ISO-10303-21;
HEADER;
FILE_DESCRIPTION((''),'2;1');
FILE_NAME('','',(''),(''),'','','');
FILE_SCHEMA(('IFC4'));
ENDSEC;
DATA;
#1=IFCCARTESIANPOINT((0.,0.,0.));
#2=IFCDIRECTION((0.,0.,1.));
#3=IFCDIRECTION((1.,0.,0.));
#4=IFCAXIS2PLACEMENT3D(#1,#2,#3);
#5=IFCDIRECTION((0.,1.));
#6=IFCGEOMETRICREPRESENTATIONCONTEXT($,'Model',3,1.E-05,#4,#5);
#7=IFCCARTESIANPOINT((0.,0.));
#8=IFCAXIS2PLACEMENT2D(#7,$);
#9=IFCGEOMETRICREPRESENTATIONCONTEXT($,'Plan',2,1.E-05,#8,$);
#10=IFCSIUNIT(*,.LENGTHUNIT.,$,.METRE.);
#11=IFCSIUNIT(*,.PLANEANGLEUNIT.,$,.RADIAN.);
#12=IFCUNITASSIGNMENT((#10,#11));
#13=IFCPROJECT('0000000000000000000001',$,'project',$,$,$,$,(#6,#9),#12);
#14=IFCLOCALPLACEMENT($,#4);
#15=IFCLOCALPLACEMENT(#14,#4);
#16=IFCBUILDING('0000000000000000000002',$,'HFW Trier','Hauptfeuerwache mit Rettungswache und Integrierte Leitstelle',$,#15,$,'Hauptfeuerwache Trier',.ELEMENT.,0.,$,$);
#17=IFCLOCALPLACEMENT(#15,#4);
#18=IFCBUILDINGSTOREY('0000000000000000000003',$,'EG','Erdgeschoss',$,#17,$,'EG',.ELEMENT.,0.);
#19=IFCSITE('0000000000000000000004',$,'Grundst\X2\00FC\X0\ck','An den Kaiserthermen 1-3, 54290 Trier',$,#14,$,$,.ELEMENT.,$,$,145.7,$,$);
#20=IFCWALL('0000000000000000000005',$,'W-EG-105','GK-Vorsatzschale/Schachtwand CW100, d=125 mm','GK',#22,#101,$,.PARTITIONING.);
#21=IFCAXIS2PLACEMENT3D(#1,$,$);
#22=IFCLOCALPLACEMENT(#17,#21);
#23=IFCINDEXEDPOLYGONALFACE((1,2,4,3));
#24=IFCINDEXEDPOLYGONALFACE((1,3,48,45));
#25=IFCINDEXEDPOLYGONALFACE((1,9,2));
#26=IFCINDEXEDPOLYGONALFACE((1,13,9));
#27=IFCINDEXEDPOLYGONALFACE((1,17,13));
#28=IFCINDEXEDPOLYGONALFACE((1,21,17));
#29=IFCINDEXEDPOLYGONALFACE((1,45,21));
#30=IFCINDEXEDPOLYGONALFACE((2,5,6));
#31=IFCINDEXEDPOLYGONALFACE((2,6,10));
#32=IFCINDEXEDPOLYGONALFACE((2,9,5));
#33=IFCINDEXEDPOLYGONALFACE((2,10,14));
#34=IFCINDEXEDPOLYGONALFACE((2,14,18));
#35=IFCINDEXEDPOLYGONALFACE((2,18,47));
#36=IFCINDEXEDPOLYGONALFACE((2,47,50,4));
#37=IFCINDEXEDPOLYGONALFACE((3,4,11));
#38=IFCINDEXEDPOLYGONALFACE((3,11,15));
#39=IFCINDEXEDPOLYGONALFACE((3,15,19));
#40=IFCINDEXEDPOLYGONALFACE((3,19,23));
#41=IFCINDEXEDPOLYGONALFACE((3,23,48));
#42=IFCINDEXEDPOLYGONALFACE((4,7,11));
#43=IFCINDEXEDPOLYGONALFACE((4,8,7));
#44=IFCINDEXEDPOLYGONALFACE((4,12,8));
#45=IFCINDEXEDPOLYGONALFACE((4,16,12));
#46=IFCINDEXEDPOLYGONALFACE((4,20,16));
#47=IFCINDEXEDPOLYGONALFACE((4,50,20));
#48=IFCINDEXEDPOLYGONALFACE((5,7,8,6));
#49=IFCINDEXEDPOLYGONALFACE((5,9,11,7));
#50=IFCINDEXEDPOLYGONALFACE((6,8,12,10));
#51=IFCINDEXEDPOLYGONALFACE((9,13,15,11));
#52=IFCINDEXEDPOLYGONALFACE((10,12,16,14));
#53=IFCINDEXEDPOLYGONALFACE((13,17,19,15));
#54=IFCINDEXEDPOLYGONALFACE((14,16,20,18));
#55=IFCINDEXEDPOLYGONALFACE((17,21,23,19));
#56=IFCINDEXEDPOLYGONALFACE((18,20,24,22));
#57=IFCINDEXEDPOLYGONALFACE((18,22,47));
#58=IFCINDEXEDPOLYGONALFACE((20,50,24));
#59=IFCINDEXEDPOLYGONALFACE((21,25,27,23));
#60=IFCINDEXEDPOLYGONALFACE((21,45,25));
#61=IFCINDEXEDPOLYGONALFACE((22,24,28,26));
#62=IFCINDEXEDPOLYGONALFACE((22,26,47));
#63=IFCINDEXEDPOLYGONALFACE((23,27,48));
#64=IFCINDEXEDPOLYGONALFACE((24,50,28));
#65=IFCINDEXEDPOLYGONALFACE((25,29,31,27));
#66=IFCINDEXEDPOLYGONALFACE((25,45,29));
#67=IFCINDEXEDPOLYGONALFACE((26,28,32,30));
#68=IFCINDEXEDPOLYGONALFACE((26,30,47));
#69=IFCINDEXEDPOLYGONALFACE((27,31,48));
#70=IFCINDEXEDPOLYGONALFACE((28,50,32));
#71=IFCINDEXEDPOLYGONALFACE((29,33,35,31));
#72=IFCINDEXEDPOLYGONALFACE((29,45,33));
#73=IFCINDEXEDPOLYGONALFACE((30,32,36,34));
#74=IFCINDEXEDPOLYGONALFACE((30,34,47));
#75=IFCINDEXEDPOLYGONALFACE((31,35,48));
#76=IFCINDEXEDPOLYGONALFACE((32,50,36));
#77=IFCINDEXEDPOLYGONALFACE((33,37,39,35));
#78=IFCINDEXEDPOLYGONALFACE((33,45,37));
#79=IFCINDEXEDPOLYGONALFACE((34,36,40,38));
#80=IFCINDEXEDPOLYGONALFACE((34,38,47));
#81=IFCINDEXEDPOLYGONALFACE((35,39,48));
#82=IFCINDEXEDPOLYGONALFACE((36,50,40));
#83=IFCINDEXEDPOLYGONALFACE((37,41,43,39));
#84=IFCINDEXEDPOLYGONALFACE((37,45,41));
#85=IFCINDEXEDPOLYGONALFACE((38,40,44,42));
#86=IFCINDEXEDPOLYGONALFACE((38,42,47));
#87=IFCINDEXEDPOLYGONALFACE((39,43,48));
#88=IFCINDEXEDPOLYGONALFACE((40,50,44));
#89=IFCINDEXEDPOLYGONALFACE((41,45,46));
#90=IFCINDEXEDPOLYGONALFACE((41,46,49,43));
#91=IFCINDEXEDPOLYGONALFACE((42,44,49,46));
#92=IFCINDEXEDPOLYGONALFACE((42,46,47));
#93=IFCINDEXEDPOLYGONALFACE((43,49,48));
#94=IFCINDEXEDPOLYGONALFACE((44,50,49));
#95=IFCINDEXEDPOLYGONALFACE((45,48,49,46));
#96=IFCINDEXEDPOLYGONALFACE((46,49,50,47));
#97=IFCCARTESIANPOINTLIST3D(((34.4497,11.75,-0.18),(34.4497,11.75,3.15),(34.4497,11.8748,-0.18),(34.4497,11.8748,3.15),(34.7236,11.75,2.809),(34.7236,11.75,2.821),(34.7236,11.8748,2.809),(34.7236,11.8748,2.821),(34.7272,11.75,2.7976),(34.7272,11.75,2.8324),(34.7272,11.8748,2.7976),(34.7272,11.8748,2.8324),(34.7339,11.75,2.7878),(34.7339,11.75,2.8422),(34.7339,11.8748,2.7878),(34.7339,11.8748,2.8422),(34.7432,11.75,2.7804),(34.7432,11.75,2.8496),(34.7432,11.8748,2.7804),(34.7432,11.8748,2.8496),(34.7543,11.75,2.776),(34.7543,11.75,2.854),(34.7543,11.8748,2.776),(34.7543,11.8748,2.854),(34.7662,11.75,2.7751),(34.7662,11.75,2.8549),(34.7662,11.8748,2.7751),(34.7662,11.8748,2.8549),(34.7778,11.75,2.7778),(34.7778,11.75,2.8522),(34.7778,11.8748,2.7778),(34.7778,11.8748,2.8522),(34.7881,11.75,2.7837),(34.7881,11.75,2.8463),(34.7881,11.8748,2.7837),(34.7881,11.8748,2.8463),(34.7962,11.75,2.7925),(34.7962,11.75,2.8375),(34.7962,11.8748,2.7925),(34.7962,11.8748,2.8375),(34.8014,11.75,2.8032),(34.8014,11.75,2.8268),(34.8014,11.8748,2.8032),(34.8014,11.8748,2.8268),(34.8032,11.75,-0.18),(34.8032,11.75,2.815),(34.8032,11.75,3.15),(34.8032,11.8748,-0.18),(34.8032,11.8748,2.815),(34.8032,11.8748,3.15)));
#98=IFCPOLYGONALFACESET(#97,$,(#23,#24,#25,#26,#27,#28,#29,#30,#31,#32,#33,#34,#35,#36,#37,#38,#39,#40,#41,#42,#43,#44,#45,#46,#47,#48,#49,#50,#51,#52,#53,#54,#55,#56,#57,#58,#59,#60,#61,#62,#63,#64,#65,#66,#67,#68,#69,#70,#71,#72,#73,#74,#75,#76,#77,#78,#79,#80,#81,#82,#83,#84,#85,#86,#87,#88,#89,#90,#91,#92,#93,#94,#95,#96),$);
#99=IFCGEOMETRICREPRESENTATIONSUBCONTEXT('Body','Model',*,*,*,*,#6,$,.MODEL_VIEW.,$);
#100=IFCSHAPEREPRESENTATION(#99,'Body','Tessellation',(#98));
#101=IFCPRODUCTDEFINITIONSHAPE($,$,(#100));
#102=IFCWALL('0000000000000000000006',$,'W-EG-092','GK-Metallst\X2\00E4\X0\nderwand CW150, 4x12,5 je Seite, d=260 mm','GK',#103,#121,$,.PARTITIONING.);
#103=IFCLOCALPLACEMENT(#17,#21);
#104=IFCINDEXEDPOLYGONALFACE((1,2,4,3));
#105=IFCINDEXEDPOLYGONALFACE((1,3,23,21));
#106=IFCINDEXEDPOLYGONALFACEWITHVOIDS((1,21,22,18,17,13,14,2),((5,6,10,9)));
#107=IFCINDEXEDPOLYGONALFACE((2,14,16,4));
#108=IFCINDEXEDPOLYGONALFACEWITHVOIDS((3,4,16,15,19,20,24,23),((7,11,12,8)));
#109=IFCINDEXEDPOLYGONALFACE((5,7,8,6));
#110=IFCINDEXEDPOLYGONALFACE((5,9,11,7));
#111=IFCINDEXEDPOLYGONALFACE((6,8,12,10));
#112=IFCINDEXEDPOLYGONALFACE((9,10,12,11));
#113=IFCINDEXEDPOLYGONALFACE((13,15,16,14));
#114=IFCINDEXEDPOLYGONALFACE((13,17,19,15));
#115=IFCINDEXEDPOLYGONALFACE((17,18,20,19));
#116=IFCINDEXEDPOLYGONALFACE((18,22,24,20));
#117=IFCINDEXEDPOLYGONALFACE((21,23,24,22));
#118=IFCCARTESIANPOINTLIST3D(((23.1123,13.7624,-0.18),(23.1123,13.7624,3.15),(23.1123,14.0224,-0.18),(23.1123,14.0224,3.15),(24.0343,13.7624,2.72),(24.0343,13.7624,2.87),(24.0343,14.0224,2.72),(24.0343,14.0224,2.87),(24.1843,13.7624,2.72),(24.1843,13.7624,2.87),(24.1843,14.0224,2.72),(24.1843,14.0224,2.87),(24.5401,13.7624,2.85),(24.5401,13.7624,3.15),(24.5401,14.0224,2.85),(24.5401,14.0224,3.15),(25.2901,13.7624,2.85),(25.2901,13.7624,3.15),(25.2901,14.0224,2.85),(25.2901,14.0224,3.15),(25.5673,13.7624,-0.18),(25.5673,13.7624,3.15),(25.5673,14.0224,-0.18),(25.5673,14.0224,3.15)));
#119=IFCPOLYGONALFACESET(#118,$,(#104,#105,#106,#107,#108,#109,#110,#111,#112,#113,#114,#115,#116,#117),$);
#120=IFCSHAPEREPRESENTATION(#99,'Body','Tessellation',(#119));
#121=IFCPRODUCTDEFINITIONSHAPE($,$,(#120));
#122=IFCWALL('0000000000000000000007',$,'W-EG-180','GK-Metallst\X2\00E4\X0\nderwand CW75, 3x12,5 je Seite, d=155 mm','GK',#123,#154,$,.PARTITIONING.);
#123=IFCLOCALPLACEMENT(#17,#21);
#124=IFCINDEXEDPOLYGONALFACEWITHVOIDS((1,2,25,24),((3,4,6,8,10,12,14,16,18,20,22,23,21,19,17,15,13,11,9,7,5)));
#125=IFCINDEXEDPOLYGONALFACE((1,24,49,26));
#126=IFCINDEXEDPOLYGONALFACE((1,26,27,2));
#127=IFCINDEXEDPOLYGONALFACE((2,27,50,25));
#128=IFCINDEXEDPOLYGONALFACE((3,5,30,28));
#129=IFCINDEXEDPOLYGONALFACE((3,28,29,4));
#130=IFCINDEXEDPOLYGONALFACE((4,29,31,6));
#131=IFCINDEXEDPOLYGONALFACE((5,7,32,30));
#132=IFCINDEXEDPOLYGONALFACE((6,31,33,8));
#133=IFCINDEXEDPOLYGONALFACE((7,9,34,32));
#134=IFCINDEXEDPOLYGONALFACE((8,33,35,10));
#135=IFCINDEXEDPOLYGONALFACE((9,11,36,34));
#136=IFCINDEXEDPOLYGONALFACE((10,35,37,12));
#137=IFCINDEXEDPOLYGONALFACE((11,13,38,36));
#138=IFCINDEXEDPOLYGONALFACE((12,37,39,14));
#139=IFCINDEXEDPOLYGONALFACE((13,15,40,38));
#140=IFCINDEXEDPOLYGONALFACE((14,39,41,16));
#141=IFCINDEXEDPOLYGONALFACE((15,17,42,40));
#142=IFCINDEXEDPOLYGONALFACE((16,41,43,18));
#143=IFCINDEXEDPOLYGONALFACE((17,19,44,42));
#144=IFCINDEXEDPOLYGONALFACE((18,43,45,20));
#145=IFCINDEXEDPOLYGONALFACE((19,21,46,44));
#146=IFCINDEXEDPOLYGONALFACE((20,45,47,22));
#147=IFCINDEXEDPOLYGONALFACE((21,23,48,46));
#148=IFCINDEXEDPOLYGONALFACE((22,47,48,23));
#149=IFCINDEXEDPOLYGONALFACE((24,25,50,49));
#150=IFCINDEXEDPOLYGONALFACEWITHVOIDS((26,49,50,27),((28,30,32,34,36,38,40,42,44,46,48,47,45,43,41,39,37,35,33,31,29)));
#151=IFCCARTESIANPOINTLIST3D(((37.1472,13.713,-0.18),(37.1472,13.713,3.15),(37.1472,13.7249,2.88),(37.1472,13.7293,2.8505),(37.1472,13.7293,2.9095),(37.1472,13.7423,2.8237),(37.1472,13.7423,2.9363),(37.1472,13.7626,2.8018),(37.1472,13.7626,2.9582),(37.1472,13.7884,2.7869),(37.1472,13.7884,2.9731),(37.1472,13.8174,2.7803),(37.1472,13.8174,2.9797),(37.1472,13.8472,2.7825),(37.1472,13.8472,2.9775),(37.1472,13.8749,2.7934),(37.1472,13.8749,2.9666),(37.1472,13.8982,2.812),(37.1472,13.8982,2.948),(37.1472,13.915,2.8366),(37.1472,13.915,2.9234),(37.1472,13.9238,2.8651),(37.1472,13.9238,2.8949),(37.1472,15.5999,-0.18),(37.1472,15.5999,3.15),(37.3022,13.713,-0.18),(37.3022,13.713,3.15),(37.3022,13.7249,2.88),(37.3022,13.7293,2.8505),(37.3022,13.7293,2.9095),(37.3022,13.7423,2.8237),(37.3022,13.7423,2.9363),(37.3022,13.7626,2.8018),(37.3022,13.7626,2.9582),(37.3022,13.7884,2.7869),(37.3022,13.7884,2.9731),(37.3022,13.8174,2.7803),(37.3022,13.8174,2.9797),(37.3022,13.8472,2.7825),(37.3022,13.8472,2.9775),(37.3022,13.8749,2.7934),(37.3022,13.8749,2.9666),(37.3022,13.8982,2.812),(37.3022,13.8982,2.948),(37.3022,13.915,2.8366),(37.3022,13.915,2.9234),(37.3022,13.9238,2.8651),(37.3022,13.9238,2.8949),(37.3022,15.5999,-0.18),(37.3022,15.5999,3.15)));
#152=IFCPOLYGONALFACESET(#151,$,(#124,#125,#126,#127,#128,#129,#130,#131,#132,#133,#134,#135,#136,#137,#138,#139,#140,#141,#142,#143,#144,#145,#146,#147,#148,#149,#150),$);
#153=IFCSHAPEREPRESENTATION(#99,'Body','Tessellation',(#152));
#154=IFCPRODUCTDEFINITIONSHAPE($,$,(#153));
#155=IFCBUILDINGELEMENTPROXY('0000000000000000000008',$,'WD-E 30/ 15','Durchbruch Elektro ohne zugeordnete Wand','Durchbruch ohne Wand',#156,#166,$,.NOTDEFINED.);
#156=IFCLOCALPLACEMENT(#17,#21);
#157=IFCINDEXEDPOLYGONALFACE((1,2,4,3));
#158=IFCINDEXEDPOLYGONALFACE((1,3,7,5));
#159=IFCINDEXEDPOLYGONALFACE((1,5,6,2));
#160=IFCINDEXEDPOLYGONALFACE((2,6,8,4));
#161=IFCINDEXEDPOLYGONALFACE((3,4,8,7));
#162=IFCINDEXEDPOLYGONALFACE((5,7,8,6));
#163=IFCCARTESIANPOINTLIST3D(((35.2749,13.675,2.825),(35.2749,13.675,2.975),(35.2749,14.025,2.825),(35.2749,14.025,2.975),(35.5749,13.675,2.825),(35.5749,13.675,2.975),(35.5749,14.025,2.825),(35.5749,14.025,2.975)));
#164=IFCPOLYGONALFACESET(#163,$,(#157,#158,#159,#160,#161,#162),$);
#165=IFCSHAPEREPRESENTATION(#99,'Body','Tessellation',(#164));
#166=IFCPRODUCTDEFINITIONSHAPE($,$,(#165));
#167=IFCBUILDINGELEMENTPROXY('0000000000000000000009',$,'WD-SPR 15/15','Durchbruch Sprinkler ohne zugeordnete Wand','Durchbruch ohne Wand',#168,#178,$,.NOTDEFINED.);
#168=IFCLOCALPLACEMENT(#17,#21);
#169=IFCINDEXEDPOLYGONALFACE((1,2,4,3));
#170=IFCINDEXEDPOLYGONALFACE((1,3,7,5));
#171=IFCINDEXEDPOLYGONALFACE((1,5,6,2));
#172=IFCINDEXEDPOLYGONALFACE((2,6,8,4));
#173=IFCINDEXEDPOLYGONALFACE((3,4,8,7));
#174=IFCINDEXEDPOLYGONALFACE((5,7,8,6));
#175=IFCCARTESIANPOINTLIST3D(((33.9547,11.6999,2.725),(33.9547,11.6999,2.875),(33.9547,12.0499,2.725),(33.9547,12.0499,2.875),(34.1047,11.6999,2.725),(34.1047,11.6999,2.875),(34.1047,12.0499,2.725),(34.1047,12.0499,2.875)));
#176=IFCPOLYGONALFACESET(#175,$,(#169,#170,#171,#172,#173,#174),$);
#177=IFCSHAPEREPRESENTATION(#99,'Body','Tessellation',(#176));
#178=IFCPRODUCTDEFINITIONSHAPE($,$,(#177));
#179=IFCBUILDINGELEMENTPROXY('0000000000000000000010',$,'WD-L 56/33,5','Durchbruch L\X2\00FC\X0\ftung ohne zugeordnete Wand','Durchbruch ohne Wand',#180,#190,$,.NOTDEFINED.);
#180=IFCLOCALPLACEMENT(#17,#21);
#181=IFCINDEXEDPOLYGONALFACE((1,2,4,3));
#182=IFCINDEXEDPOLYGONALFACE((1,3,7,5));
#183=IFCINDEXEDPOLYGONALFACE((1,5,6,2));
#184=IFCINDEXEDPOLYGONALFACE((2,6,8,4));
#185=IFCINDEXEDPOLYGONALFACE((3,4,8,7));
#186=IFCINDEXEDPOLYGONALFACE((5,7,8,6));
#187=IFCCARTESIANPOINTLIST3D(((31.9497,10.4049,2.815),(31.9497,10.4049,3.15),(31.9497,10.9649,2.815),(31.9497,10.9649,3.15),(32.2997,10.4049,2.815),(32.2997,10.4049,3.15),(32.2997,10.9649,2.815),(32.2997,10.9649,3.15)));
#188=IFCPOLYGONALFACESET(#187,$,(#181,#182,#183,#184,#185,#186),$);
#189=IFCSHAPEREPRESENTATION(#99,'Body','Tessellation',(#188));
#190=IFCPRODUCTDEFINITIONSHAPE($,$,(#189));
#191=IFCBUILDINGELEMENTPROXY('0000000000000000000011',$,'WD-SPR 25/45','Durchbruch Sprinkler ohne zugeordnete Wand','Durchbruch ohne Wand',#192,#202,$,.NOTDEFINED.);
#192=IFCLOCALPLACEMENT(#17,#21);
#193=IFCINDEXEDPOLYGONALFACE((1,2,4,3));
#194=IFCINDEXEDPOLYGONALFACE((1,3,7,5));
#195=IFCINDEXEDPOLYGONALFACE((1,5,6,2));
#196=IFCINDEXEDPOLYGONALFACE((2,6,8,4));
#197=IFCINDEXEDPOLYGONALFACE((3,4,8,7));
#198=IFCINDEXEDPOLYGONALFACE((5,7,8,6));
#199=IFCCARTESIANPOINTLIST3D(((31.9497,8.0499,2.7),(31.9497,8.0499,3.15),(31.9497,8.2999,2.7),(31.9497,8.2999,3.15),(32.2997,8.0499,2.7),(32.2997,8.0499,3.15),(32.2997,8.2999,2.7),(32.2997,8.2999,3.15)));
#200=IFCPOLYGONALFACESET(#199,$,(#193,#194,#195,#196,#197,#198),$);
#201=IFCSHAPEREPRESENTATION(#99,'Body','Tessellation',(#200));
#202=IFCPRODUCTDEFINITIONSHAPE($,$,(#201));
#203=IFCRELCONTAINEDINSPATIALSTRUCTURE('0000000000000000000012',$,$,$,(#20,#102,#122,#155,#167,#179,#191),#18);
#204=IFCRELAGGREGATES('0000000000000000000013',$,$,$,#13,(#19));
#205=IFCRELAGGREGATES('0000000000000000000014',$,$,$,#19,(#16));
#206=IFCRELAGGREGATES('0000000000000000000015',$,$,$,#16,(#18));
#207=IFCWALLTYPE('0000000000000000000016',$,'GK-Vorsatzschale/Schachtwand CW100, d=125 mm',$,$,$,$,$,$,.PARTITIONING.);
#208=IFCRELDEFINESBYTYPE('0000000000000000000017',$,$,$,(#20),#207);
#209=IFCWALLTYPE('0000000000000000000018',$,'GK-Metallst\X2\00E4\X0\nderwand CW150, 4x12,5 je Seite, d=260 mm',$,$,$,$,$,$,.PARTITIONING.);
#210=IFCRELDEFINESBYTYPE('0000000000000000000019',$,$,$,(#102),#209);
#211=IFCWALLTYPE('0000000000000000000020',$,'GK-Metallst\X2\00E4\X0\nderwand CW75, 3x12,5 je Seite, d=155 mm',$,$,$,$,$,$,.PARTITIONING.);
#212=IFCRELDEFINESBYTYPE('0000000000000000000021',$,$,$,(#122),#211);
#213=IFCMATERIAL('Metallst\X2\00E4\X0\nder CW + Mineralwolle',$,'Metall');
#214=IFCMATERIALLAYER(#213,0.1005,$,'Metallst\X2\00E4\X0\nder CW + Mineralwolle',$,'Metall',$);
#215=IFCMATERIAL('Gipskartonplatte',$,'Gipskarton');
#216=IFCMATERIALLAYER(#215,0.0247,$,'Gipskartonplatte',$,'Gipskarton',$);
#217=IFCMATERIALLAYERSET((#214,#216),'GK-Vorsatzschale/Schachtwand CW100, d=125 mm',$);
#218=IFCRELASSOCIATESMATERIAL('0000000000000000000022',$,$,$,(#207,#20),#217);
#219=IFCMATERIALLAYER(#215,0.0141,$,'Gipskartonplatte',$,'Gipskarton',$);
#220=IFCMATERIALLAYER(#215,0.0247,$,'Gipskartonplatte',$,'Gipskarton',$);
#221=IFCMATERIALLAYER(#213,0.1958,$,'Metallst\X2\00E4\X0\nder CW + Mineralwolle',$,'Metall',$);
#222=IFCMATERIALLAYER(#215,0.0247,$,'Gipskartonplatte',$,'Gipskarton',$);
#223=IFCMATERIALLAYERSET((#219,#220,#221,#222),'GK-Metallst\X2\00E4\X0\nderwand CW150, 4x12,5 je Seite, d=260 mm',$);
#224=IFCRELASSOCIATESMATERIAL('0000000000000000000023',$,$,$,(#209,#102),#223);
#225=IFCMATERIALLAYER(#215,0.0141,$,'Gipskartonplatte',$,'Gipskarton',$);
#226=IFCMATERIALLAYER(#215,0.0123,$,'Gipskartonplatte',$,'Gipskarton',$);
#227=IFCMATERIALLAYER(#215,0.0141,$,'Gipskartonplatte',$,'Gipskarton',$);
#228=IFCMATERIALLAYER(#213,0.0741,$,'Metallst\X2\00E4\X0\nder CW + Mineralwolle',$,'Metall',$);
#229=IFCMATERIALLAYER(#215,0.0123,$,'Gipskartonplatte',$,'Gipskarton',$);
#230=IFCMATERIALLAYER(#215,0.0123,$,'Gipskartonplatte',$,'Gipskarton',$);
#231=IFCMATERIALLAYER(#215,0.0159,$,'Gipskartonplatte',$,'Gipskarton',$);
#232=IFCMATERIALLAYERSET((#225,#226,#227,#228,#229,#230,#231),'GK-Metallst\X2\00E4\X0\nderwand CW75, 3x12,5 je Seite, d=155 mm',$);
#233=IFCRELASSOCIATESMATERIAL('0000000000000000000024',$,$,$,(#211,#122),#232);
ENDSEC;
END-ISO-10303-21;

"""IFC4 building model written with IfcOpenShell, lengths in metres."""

from ifc_helpers import new_model, si_unit, direction, frame, frame_2d, origin_with_axes, origin_2d, place, context, subcontext, project, spatial, rectangle, circle, extrude, material, layer, layer_set, layer_usage, type_object, element, save


model = new_model("IFC4")

# Units and contexts
model_context = context("Model", 3, precision=1e-05, world=origin_with_axes(), true_north=direction((0.0, 1.0)))
plan_context = context("Plan", 2, precision=1e-05, world=origin_2d())
body_context = subcontext(model_context, "Body", "Model", "MODEL_VIEW")
ifc_project = project(units=[si_unit("LENGTHUNIT", "METRE"), si_unit("PLANEANGLEUNIT", "RADIAN")], contexts=[model_context, plan_context])

# Site, building, storey
site_placement = place(None, origin_with_axes())
site = spatial("IfcSite", under=ifc_project, at=site_placement, Name="Grundstück", Description="An den Kaiserthermen 1-3, 54290 Trier", CompositionType="ELEMENT", RefElevation=145.7)
building_placement = place(site_placement, origin_with_axes())
building = spatial("IfcBuilding", under=site, at=building_placement, Name="HFW Trier", Description="Hauptfeuerwache mit Rettungswache und Integrierte Leitstelle", LongName="Hauptfeuerwache Trier", CompositionType="ELEMENT", ElevationOfRefHeight=0.0)
storey_placement = place(building_placement, origin_with_axes())
storey = spatial("IfcBuildingStorey", under=building, at=storey_placement, Name="EG", Description="Erdgeschoss", LongName="EG", CompositionType="ELEMENT", Elevation=0.0)

# Shared definitions
ifc_material_1 = material(Name="Metallständer CW + Mineralwolle", Category="Metall")

# Shared definitions
ifc_material_2 = material(Name="Gipskartonplatte", Category="Gipskarton")

# Wall, opening
ifc_layer_1 = layer(ifc_material_1, 0.1005, Name="Metallständer CW + Mineralwolle", Category="Metall")
ifc_layer_2 = layer(ifc_material_2, 0.0247, Name="Gipskartonplatte", Category="Gipskarton")
ifc_layer_set_1 = layer_set([ifc_layer_1, ifc_layer_2], Name="GK-Vorsatzschale/Schachtwand CW100, d=125 mm")
ifc_layer_usage_1 = layer_usage(ifc_layer_set_1, "AXIS2", "POSITIVE", -0.0624)
wall_type_1 = type_object("IfcWallType", Name="GK-Vorsatzschale/Schachtwand CW100, d=125 mm", PredefinedType="PARTITIONING", material=ifc_layer_set_1)
wall_1_placement = place(storey_placement, frame((34.4497, 11.8124, -0.18), z_axis=(0.0, 0.0, 1.0), x_axis=(1.0, 0.0, 0.0)))
wall_1 = element("IfcWall", 1, at=wall_1_placement, inside=storey, type_object=wall_type_1, material=ifc_layer_usage_1, Name="W-EG-105", Description="GK-Vorsatzschale/Schachtwand CW100, d=125 mm", ObjectType="GK", PredefinedType="PARTITIONING", context=body_context, shape_type="SweptSolid", body=[
    extrude(rectangle(XDim=0.3535, YDim=0.1249, at=frame_2d((0.1767, 0.0))), origin_with_axes(), (0.0, 0.0, 1.0), 3.33),
])
opening_1_placement = place(wall_1_placement, origin_with_axes())
element("IfcOpeningElement", 2, at=opening_1_placement, cuts=wall_1, ObjectType="Wanddurchbruch", PredefinedType="OPENING", context=body_context, shape_type="SweptSolid", body=[
    extrude(circle(Radius=0.04, at=origin_2d()), frame((0.3135, -0.1124, 2.995), z_axis=(0.0, 1.0, 0.0), x_axis=(1.0, 0.0, 0.0)), (0.0, 0.0, 1.0), 0.2249),
])

# Wall, openings
ifc_layer_3 = layer(ifc_material_2, 0.0141, Name="Gipskartonplatte", Category="Gipskarton")
ifc_layer_4 = layer(ifc_material_2, 0.0247, Name="Gipskartonplatte", Category="Gipskarton")
ifc_layer_5 = layer(ifc_material_1, 0.1958, Name="Metallständer CW + Mineralwolle", Category="Metall")
ifc_layer_6 = layer(ifc_material_2, 0.0247, Name="Gipskartonplatte", Category="Gipskarton")
ifc_layer_set_2 = layer_set([ifc_layer_3, ifc_layer_4, ifc_layer_5, ifc_layer_6], Name="GK-Metallständerwand CW150, 4x12,5 je Seite, d=260 mm")
ifc_layer_usage_2 = layer_usage(ifc_layer_set_2, "AXIS2", "POSITIVE", -0.13)
wall_type_2 = type_object("IfcWallType", Name="GK-Metallständerwand CW150, 4x12,5 je Seite, d=260 mm", PredefinedType="PARTITIONING", material=ifc_layer_set_2)
wall_2_placement = place(storey_placement, frame((23.1123, 13.8924, -0.18), z_axis=(0.0, 0.0, 1.0), x_axis=(1.0, 0.0, 0.0)))
wall_2 = element("IfcWall", 3, at=wall_2_placement, inside=storey, type_object=wall_type_2, material=ifc_layer_usage_2, Name="W-EG-092", Description="GK-Metallständerwand CW150, 4x12,5 je Seite, d=260 mm", ObjectType="GK", PredefinedType="PARTITIONING", context=body_context, shape_type="SweptSolid", body=[
    extrude(rectangle(XDim=2.455, YDim=0.26, at=frame_2d((1.2275, 0.0))), origin_with_axes(), (0.0, 0.0, 1.0), 3.33),
])
opening_2_placement = place(wall_2_placement, origin_with_axes())
element("IfcOpeningElement", 4, at=opening_2_placement, cuts=wall_2, ObjectType="Wanddurchbruch", PredefinedType="OPENING", context=body_context, shape_type="SweptSolid", body=[
    extrude(rectangle(XDim=0.75, YDim=0.36, at=frame_2d((1.8028, 0.0))), frame((0.0, 0.0, 3.03), z_axis=(0.0, 0.0, 1.0), x_axis=(1.0, 0.0, 0.0)), (0.0, 0.0, 1.0), 0.3),
])
opening_3_placement = place(wall_2_placement, origin_with_axes())
element("IfcOpeningElement", 5, at=opening_3_placement, cuts=wall_2, ObjectType="Wanddurchbruch", PredefinedType="OPENING", context=body_context, shape_type="SweptSolid", body=[
    extrude(rectangle(XDim=0.15, YDim=0.36, at=frame_2d((0.997, 0.0))), frame((0.0, 0.0, 2.9), z_axis=(0.0, 0.0, 1.0), x_axis=(1.0, 0.0, 0.0)), (0.0, 0.0, 1.0), 0.15),
])

# Wall, opening
ifc_layer_7 = layer(ifc_material_2, 0.0141, Name="Gipskartonplatte", Category="Gipskarton")
ifc_layer_8 = layer(ifc_material_2, 0.0123, Name="Gipskartonplatte", Category="Gipskarton")
ifc_layer_9 = layer(ifc_material_2, 0.0141, Name="Gipskartonplatte", Category="Gipskarton")
ifc_layer_10 = layer(ifc_material_1, 0.0741, Name="Metallständer CW + Mineralwolle", Category="Metall")
ifc_layer_11 = layer(ifc_material_2, 0.0123, Name="Gipskartonplatte", Category="Gipskarton")
ifc_layer_12 = layer(ifc_material_2, 0.0123, Name="Gipskartonplatte", Category="Gipskarton")
ifc_layer_13 = layer(ifc_material_2, 0.0159, Name="Gipskartonplatte", Category="Gipskarton")
ifc_layer_set_3 = layer_set([ifc_layer_7, ifc_layer_8, ifc_layer_9, ifc_layer_10, ifc_layer_11, ifc_layer_12, ifc_layer_13], Name="GK-Metallständerwand CW75, 3x12,5 je Seite, d=155 mm")
ifc_layer_usage_3 = layer_usage(ifc_layer_set_3, "AXIS2", "POSITIVE", -0.0775)
wall_type_3 = type_object("IfcWallType", Name="GK-Metallständerwand CW75, 3x12,5 je Seite, d=155 mm", PredefinedType="PARTITIONING", material=ifc_layer_set_3)
wall_3_placement = place(storey_placement, frame((37.2247, 15.5999, -0.18), z_axis=(0.0, 0.0, 1.0), x_axis=(0.0, -1.0, 0.0)))
wall_3 = element("IfcWall", 6, at=wall_3_placement, inside=storey, type_object=wall_type_3, material=ifc_layer_usage_3, Name="W-EG-180", Description="GK-Metallständerwand CW75, 3x12,5 je Seite, d=155 mm", ObjectType="GK", PredefinedType="PARTITIONING", context=body_context, shape_type="SweptSolid", body=[
    extrude(rectangle(XDim=1.8869, YDim=0.155, at=frame_2d((0.9435, 0.0))), origin_with_axes(), (0.0, 0.0, 1.0), 3.33),
])
opening_4_placement = place(wall_3_placement, origin_with_axes())
element("IfcOpeningElement", 7, at=opening_4_placement, cuts=wall_3, ObjectType="Wanddurchbruch", PredefinedType="OPENING", context=body_context, shape_type="SweptSolid", body=[
    extrude(circle(Radius=0.1, at=origin_2d()), frame((1.775, -0.1275, 3.06), z_axis=(0.0, 1.0, 0.0), x_axis=(1.0, 0.0, 0.0)), (0.0, 0.0, 1.0), 0.255),
])

# Building element proxies
proxy_1_placement = place(storey_placement, frame((35.4249, 13.85, 2.825), z_axis=(0.0, 0.0, 1.0), x_axis=(1.0, 0.0, 0.0)))
element("IfcBuildingElementProxy", 8, at=proxy_1_placement, inside=storey, Name="WD-E 30/ 15", Description="Durchbruch Elektro ohne zugeordnete Wand", ObjectType="Durchbruch ohne Wand", PredefinedType="NOTDEFINED", context=body_context, shape_type="SweptSolid", body=[
    extrude(rectangle(XDim=0.3, YDim=0.35, at=origin_2d()), origin_with_axes(), (0.0, 0.0, 1.0), 0.15),
])
proxy_2_placement = place(storey_placement, frame((34.0297, 11.8749, 2.725), z_axis=(0.0, 0.0, 1.0), x_axis=(1.0, 0.0, 0.0)))
element("IfcBuildingElementProxy", 9, at=proxy_2_placement, inside=storey, Name="WD-SPR 15/15", Description="Durchbruch Sprinkler ohne zugeordnete Wand", ObjectType="Durchbruch ohne Wand", PredefinedType="NOTDEFINED", context=body_context, shape_type="SweptSolid", body=[
    extrude(rectangle(XDim=0.15, YDim=0.35, at=origin_2d()), origin_with_axes(), (0.0, 0.0, 1.0), 0.15),
])
proxy_3_placement = place(storey_placement, frame((32.1247, 10.6849, 2.815), z_axis=(0.0, 0.0, 1.0), x_axis=(0.0, 1.0, 0.0)))
element("IfcBuildingElementProxy", 10, at=proxy_3_placement, inside=storey, Name="WD-L 56/33,5", Description="Durchbruch Lüftung ohne zugeordnete Wand", ObjectType="Durchbruch ohne Wand", PredefinedType="NOTDEFINED", context=body_context, shape_type="SweptSolid", body=[
    extrude(rectangle(XDim=0.56, YDim=0.35, at=origin_2d()), origin_with_axes(), (0.0, 0.0, 1.0), 0.335),
])
proxy_4_placement = place(storey_placement, frame((32.1247, 8.1749, 2.7), z_axis=(0.0, 0.0, 1.0), x_axis=(0.0, 1.0, 0.0)))
element("IfcBuildingElementProxy", 11, at=proxy_4_placement, inside=storey, Name="WD-SPR 25/45", Description="Durchbruch Sprinkler ohne zugeordnete Wand", ObjectType="Durchbruch ohne Wand", PredefinedType="NOTDEFINED", context=body_context, shape_type="SweptSolid", body=[
    extrude(rectangle(XDim=0.25, YDim=0.35, at=origin_2d()), origin_with_axes(), (0.0, 0.0, 1.0), 0.45),
])

save(model, "model.ifc")
